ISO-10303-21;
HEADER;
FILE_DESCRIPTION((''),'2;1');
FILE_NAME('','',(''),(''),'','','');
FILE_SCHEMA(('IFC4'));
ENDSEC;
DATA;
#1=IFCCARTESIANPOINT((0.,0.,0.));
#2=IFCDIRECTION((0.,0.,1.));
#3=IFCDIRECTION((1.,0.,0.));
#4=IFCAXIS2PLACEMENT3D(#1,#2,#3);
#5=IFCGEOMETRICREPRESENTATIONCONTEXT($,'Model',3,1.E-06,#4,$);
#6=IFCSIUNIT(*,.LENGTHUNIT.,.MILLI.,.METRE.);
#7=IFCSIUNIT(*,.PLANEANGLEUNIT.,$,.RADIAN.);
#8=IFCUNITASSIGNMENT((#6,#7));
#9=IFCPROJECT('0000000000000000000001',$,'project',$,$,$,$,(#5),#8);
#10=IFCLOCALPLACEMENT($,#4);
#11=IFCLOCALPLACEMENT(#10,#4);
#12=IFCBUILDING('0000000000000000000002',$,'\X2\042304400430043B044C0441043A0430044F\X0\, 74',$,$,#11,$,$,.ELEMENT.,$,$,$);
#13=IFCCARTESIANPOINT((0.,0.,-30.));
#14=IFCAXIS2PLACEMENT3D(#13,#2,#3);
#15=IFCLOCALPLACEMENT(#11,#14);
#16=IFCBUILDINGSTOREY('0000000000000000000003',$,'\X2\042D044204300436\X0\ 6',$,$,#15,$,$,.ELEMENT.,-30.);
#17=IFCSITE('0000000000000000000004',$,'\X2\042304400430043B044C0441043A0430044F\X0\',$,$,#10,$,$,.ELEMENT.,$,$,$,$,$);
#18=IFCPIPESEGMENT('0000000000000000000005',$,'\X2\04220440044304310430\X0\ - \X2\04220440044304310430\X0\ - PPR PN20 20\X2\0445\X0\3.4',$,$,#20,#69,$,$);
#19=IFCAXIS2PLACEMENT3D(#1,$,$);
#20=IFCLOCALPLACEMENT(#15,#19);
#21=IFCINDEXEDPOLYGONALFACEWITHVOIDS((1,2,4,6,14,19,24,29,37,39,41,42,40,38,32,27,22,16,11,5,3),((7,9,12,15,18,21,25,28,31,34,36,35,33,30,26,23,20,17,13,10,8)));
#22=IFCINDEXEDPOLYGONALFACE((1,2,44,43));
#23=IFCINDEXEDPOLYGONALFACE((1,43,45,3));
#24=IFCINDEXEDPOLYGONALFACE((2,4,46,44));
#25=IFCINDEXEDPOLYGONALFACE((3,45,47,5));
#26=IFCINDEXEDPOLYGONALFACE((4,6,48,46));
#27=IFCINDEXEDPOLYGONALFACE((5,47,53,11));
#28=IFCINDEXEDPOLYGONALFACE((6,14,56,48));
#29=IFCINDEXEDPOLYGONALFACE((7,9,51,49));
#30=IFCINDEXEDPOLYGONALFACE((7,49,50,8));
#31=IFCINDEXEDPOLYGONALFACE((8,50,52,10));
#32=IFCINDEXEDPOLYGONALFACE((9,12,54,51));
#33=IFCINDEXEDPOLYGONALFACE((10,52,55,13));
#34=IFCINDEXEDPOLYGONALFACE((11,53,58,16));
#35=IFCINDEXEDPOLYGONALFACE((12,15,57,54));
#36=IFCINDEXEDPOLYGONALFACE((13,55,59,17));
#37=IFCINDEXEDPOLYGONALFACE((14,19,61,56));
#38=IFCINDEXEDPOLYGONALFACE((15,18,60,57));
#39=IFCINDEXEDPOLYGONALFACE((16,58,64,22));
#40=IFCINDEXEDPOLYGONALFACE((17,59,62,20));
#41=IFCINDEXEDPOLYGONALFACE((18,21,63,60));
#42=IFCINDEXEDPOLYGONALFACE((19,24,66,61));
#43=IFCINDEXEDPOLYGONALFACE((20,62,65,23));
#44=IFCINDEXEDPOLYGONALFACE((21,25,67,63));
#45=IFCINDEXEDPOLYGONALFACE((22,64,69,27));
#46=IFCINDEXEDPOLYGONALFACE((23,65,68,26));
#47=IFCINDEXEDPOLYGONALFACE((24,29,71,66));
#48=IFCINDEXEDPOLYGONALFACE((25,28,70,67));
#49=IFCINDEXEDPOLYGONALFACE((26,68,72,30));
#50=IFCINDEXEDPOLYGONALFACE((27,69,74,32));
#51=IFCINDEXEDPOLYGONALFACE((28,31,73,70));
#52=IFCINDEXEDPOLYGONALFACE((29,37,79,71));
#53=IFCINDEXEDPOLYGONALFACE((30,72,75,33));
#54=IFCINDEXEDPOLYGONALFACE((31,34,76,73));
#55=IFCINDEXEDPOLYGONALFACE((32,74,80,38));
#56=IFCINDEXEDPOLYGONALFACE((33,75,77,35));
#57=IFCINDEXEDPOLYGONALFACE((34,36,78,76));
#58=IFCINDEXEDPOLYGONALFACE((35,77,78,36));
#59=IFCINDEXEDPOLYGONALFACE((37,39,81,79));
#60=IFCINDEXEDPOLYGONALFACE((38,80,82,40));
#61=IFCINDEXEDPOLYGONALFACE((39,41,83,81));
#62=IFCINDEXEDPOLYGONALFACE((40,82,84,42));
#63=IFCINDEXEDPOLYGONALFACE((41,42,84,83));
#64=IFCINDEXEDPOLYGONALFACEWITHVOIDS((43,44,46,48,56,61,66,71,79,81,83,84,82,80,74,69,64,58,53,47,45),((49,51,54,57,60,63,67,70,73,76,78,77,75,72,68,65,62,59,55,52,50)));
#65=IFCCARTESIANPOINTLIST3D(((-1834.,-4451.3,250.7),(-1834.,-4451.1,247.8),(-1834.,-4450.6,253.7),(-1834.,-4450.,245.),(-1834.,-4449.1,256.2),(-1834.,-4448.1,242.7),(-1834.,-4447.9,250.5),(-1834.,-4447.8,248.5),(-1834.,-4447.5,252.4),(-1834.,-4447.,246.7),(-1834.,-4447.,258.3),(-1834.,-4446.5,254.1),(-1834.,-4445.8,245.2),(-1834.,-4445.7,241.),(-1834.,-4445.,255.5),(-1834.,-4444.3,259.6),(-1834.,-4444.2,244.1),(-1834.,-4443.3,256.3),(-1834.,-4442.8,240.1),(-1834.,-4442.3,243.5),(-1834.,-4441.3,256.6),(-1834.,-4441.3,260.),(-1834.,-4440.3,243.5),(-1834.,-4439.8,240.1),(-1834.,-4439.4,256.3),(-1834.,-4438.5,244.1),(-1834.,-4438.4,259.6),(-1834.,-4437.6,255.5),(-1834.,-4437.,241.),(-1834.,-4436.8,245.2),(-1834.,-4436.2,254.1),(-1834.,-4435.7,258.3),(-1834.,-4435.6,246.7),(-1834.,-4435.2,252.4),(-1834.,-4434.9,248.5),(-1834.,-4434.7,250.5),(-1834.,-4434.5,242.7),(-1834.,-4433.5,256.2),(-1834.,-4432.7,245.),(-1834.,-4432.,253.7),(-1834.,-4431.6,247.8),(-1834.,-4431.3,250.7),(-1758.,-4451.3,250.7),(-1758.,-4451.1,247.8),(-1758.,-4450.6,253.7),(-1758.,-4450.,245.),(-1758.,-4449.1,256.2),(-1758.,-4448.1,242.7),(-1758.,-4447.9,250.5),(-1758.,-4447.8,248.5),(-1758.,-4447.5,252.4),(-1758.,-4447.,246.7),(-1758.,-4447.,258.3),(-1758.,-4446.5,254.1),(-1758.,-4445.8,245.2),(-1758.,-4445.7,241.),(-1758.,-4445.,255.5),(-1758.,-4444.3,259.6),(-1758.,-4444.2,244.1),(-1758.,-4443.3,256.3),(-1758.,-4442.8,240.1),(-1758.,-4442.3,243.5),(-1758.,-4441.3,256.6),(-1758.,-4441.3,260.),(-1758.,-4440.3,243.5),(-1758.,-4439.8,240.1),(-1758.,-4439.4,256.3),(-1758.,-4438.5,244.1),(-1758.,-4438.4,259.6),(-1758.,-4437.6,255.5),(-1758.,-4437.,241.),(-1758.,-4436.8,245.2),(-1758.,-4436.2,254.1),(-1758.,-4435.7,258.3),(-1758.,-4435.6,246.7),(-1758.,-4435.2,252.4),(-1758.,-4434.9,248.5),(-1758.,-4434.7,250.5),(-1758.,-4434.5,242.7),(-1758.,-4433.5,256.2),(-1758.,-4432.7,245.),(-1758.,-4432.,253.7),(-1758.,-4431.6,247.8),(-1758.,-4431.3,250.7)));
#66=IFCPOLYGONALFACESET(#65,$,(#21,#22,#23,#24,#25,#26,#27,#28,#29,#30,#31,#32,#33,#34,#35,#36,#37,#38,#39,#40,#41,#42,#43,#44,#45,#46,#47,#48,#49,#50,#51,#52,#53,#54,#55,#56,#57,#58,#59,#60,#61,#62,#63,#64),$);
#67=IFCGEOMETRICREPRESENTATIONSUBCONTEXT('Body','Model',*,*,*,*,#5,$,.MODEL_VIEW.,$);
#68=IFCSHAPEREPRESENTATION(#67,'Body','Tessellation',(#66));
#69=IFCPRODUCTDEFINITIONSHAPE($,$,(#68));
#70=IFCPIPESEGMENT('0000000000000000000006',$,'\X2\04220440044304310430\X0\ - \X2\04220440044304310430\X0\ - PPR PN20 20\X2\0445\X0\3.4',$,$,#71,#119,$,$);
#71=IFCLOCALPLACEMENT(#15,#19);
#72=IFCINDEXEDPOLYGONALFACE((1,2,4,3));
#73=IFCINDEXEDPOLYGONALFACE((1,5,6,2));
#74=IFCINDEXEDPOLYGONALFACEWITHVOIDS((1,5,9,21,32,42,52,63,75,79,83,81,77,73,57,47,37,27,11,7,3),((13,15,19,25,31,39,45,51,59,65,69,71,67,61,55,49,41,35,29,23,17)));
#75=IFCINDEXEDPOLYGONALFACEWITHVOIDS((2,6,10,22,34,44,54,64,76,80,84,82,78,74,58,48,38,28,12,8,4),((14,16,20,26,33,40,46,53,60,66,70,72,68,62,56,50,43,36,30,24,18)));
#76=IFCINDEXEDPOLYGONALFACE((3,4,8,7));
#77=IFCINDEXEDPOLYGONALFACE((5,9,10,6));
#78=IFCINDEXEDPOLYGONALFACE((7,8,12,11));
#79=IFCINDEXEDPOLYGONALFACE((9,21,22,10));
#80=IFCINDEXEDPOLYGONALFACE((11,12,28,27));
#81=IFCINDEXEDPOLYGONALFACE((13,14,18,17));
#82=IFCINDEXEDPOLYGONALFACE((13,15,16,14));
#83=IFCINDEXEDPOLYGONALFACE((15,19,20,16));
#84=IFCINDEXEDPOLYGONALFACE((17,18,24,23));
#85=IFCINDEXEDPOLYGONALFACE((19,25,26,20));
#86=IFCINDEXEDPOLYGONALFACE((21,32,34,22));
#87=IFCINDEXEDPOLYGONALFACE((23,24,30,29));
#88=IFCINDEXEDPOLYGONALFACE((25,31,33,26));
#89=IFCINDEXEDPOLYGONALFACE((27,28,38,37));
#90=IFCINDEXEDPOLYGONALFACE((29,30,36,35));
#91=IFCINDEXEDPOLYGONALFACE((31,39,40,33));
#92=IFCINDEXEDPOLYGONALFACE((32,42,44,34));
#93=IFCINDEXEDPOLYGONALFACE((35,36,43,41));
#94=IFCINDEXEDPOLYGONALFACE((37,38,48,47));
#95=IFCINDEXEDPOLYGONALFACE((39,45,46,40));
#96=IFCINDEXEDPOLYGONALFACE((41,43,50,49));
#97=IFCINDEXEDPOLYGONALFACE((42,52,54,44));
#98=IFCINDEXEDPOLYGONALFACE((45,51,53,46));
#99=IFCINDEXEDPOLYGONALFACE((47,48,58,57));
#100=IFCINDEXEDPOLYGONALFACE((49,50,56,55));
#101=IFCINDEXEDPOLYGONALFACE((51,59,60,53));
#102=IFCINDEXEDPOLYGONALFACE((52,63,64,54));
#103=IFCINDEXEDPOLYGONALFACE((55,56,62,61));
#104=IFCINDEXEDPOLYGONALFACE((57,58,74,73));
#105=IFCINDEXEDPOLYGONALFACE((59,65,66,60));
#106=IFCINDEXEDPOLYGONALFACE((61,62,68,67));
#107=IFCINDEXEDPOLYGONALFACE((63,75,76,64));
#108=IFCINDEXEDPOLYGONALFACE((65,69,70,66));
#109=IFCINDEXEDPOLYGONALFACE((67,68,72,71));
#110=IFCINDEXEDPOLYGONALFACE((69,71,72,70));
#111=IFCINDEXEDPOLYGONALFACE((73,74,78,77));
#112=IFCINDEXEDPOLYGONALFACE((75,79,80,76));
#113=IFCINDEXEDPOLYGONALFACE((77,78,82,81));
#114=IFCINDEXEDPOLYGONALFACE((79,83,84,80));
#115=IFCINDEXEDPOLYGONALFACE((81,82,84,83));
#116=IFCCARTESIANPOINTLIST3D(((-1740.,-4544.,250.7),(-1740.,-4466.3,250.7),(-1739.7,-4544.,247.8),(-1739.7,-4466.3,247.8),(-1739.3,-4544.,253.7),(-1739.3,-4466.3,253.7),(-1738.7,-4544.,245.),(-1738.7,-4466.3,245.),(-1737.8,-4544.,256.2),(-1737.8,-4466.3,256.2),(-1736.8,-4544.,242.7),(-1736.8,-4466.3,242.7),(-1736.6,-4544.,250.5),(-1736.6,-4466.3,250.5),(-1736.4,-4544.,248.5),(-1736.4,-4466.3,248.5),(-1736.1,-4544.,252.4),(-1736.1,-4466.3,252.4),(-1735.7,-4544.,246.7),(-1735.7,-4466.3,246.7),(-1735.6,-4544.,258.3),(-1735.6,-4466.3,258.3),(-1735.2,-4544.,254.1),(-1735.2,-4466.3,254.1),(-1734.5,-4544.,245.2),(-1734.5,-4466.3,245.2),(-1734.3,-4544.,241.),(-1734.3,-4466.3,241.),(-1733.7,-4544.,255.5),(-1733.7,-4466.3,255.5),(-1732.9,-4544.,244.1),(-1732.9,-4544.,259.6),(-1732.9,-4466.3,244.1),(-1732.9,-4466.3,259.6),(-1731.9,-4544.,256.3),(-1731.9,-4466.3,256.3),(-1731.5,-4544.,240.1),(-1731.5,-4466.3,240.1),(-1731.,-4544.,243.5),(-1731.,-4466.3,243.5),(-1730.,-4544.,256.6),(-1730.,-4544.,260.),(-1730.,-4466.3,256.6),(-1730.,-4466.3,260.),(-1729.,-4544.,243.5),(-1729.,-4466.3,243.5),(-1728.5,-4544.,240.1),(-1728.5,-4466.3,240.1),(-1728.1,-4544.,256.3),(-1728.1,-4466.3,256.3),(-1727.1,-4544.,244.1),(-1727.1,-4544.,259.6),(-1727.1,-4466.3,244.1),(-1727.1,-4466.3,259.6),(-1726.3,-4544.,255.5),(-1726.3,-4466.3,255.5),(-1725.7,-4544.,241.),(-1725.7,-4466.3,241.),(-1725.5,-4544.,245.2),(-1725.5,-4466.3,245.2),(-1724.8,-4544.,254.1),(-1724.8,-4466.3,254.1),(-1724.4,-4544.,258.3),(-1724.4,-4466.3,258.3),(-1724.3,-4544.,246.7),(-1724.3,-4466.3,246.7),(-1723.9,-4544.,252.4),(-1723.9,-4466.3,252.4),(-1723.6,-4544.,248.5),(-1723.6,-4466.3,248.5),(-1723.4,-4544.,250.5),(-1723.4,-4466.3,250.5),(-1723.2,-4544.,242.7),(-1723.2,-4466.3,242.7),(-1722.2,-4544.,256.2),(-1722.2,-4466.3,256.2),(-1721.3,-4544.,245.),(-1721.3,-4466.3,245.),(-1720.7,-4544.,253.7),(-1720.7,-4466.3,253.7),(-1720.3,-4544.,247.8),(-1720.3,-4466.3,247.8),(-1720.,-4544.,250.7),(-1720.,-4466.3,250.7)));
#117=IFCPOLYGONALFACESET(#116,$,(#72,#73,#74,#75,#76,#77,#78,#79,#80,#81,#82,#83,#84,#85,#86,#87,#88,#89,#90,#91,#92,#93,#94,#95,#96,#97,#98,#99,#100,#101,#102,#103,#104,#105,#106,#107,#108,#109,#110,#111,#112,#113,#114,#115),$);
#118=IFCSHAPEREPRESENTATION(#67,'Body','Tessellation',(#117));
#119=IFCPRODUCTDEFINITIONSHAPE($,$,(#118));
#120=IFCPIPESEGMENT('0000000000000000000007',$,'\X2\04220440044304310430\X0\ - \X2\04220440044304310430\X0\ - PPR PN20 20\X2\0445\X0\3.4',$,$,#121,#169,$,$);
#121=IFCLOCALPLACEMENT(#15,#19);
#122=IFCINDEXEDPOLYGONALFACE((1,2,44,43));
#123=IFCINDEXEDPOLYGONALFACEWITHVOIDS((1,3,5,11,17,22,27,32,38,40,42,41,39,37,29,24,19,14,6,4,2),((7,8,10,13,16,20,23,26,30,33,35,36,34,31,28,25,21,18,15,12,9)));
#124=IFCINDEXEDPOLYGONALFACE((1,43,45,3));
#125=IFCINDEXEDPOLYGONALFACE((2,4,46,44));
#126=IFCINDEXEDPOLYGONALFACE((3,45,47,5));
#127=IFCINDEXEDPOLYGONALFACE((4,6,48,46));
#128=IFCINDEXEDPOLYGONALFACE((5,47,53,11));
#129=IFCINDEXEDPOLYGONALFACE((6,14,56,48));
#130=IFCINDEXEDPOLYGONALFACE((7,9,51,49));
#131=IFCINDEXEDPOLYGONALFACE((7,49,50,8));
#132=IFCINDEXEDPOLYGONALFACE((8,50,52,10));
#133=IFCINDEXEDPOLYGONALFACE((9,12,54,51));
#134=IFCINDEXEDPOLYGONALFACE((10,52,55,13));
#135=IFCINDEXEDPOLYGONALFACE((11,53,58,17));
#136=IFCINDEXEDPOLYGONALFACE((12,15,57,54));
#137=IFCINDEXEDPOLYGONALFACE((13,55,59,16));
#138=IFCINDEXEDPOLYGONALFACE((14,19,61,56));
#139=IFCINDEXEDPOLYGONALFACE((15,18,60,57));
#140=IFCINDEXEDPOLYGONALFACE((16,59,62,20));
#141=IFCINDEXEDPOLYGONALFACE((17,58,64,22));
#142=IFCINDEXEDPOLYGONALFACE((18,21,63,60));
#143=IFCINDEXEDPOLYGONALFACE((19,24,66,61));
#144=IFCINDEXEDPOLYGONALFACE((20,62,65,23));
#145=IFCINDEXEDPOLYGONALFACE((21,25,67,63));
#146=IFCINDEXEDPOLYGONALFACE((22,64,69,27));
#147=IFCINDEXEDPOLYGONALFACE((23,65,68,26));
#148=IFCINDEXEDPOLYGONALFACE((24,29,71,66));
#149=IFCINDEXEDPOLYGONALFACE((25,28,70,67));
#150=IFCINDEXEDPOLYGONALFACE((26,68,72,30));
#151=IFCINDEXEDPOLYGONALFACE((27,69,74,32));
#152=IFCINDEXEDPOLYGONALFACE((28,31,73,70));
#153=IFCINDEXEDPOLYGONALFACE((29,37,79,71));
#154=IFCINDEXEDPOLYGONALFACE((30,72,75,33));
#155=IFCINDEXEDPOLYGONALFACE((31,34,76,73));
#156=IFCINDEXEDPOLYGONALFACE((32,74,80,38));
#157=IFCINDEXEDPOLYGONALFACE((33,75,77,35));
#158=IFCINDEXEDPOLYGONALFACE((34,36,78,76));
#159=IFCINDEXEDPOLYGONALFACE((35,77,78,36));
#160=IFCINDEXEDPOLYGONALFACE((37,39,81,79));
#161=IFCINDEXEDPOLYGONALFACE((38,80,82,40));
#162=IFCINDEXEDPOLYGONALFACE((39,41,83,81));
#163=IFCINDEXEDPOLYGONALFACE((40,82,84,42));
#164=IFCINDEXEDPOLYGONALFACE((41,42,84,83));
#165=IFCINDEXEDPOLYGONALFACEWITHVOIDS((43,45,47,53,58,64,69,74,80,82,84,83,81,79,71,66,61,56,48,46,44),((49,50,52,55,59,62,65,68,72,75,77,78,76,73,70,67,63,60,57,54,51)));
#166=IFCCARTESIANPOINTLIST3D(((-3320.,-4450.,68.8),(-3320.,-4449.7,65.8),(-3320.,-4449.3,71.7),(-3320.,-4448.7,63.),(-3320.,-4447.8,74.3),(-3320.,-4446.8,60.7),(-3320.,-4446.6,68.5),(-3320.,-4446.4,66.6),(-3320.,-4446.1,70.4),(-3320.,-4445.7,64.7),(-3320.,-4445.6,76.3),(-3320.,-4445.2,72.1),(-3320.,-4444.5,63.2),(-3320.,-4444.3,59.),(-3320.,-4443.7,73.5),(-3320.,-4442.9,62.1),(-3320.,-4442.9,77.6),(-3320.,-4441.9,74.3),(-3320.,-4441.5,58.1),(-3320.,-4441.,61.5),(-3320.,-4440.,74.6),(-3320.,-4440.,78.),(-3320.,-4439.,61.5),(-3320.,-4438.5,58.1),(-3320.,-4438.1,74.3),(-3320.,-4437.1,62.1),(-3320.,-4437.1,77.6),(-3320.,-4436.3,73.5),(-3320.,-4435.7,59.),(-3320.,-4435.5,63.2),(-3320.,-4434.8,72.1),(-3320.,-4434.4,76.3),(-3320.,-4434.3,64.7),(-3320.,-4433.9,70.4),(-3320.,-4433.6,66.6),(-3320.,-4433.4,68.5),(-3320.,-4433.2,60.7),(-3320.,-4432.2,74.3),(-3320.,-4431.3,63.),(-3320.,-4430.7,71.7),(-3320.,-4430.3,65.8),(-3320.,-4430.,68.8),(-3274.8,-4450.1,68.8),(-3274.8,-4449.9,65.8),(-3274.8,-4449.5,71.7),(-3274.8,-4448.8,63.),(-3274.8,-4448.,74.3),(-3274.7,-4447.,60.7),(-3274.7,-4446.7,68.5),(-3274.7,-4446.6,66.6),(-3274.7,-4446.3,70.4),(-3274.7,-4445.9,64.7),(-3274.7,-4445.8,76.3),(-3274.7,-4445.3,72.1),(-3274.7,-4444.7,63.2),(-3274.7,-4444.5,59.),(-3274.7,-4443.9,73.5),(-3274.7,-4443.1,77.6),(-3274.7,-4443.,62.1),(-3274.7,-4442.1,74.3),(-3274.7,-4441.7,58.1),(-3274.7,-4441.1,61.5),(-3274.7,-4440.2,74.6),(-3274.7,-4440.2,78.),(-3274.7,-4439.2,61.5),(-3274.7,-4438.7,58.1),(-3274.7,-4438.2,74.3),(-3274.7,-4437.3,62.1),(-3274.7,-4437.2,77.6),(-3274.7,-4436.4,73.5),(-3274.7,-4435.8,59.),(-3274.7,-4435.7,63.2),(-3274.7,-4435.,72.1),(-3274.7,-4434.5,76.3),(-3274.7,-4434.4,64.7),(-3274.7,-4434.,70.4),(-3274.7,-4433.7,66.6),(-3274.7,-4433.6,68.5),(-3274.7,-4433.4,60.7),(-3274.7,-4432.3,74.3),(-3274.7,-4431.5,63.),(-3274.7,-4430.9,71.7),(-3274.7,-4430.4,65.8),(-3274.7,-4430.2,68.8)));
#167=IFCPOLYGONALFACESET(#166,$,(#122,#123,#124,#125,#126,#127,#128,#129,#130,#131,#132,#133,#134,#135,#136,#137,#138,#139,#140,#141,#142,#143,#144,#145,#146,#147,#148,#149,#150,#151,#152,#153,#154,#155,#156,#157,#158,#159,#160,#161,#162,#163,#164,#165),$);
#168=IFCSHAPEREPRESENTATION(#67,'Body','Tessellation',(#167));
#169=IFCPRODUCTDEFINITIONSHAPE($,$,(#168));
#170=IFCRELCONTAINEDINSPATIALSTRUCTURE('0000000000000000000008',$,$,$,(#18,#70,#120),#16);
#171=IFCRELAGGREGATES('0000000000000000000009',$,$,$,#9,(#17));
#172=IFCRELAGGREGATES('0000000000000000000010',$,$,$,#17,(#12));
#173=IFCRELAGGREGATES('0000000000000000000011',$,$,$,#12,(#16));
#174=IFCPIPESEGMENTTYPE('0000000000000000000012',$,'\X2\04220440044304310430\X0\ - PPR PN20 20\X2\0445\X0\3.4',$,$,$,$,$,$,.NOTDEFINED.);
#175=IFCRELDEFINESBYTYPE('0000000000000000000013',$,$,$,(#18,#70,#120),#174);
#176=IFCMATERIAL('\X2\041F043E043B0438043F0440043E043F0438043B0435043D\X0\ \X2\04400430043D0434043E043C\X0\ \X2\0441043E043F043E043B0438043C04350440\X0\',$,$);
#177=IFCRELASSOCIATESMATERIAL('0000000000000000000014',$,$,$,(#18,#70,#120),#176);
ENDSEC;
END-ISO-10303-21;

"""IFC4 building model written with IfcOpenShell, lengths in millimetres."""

from ifc_helpers import new_model, entity, si_unit, frame, origin_with_axes, place, context, subcontext, project, spatial, material, type_object, element, save


model = new_model("IFC4")

# Units and contexts
model_context = context("Model", 3, precision=1e-06, world=origin_with_axes())
body_context = subcontext(model_context, "Body", "Model", "MODEL_VIEW")
ifc_project = project(units=[si_unit("LENGTHUNIT", "METRE", prefix="MILLI"), si_unit("PLANEANGLEUNIT", "RADIAN")], contexts=[model_context])

# Site, building, storey
site_placement = place(None, origin_with_axes())
site = spatial("IfcSite", under=ifc_project, at=site_placement, Name="Уральская", CompositionType="ELEMENT")
building_placement = place(site_placement, origin_with_axes())
building = spatial("IfcBuilding", under=site, at=building_placement, Name="Уральская, 74", CompositionType="ELEMENT")
storey_placement = place(building_placement, frame((0.0, 0.0, -30.0), z_axis=(0.0, 0.0, 1.0), x_axis=(1.0, 0.0, 0.0)))
storey = spatial("IfcBuildingStorey", under=building, at=storey_placement, Name="Этаж 6", CompositionType="ELEMENT", Elevation=-30.0)

# Pipe segments
ifc_material_1 = material(Name="Полипропилен рандом сополимер")
pipe_segment_type_1 = type_object("IfcPipeSegmentType", Name="Труба - PPR PN20 20х3.4", PredefinedType="NOTDEFINED")
pipe_segment_1_placement = place(storey_placement, frame((-1834.0, -4441.3, 250.0), z_axis=(0.0, 0.0, 1.0), x_axis=(1.0, 0.0, 0.0)))
element("IfcPipeSegment", 1, at=pipe_segment_1_placement, inside=storey, type_object=pipe_segment_type_1, material=ifc_material_1, Name="Труба - Труба - PPR PN20 20х3.4", context=body_context, shape_type="AdvancedSweptSolid", body=[
    entity("IfcSweptDiskSolid", entity("IfcIndexedPolyCurve", entity("IfcCartesianPointList3D", [[0.0, 0.0, 0.0], [76.0, 0.0, 0.0]]), [entity("IfcLineIndex", [1, 2])]), 10.0, 6.6),
])
pipe_segment_2_placement = place(storey_placement, frame((-1730.0, -4544.0, 250.0), z_axis=(0.0, 0.0, 1.0), x_axis=(0.0, 1.0, 0.0)))
element("IfcPipeSegment", 2, at=pipe_segment_2_placement, inside=storey, type_object=pipe_segment_type_1, material=ifc_material_1, Name="Труба - Труба - PPR PN20 20х3.4", context=body_context, shape_type="AdvancedSweptSolid", body=[
    entity("IfcSweptDiskSolid", entity("IfcIndexedPolyCurve", entity("IfcCartesianPointList3D", [[0.0, 0.0, 0.0], [77.7, 0.0, 0.0]]), [entity("IfcLineIndex", [1, 2])]), 10.0, 6.6),
])
pipe_segment_3_placement = place(storey_placement, frame((-3274.7, -4440.2, 68.0), z_axis=(0.0, 0.0, 1.0), x_axis=(-0.999993, 0.003657, 0.0)))
element("IfcPipeSegment", 3, at=pipe_segment_3_placement, inside=storey, type_object=pipe_segment_type_1, material=ifc_material_1, Name="Труба - Труба - PPR PN20 20х3.4", context=body_context, shape_type="AdvancedSweptSolid", body=[
    entity("IfcSweptDiskSolid", entity("IfcIndexedPolyCurve", entity("IfcCartesianPointList3D", [[0.0, 0.0, 0.0], [45.3, 0.0, 0.0]]), [entity("IfcLineIndex", [1, 2])]), 10.0, 6.6),
])

save(model, "model.ifc")
